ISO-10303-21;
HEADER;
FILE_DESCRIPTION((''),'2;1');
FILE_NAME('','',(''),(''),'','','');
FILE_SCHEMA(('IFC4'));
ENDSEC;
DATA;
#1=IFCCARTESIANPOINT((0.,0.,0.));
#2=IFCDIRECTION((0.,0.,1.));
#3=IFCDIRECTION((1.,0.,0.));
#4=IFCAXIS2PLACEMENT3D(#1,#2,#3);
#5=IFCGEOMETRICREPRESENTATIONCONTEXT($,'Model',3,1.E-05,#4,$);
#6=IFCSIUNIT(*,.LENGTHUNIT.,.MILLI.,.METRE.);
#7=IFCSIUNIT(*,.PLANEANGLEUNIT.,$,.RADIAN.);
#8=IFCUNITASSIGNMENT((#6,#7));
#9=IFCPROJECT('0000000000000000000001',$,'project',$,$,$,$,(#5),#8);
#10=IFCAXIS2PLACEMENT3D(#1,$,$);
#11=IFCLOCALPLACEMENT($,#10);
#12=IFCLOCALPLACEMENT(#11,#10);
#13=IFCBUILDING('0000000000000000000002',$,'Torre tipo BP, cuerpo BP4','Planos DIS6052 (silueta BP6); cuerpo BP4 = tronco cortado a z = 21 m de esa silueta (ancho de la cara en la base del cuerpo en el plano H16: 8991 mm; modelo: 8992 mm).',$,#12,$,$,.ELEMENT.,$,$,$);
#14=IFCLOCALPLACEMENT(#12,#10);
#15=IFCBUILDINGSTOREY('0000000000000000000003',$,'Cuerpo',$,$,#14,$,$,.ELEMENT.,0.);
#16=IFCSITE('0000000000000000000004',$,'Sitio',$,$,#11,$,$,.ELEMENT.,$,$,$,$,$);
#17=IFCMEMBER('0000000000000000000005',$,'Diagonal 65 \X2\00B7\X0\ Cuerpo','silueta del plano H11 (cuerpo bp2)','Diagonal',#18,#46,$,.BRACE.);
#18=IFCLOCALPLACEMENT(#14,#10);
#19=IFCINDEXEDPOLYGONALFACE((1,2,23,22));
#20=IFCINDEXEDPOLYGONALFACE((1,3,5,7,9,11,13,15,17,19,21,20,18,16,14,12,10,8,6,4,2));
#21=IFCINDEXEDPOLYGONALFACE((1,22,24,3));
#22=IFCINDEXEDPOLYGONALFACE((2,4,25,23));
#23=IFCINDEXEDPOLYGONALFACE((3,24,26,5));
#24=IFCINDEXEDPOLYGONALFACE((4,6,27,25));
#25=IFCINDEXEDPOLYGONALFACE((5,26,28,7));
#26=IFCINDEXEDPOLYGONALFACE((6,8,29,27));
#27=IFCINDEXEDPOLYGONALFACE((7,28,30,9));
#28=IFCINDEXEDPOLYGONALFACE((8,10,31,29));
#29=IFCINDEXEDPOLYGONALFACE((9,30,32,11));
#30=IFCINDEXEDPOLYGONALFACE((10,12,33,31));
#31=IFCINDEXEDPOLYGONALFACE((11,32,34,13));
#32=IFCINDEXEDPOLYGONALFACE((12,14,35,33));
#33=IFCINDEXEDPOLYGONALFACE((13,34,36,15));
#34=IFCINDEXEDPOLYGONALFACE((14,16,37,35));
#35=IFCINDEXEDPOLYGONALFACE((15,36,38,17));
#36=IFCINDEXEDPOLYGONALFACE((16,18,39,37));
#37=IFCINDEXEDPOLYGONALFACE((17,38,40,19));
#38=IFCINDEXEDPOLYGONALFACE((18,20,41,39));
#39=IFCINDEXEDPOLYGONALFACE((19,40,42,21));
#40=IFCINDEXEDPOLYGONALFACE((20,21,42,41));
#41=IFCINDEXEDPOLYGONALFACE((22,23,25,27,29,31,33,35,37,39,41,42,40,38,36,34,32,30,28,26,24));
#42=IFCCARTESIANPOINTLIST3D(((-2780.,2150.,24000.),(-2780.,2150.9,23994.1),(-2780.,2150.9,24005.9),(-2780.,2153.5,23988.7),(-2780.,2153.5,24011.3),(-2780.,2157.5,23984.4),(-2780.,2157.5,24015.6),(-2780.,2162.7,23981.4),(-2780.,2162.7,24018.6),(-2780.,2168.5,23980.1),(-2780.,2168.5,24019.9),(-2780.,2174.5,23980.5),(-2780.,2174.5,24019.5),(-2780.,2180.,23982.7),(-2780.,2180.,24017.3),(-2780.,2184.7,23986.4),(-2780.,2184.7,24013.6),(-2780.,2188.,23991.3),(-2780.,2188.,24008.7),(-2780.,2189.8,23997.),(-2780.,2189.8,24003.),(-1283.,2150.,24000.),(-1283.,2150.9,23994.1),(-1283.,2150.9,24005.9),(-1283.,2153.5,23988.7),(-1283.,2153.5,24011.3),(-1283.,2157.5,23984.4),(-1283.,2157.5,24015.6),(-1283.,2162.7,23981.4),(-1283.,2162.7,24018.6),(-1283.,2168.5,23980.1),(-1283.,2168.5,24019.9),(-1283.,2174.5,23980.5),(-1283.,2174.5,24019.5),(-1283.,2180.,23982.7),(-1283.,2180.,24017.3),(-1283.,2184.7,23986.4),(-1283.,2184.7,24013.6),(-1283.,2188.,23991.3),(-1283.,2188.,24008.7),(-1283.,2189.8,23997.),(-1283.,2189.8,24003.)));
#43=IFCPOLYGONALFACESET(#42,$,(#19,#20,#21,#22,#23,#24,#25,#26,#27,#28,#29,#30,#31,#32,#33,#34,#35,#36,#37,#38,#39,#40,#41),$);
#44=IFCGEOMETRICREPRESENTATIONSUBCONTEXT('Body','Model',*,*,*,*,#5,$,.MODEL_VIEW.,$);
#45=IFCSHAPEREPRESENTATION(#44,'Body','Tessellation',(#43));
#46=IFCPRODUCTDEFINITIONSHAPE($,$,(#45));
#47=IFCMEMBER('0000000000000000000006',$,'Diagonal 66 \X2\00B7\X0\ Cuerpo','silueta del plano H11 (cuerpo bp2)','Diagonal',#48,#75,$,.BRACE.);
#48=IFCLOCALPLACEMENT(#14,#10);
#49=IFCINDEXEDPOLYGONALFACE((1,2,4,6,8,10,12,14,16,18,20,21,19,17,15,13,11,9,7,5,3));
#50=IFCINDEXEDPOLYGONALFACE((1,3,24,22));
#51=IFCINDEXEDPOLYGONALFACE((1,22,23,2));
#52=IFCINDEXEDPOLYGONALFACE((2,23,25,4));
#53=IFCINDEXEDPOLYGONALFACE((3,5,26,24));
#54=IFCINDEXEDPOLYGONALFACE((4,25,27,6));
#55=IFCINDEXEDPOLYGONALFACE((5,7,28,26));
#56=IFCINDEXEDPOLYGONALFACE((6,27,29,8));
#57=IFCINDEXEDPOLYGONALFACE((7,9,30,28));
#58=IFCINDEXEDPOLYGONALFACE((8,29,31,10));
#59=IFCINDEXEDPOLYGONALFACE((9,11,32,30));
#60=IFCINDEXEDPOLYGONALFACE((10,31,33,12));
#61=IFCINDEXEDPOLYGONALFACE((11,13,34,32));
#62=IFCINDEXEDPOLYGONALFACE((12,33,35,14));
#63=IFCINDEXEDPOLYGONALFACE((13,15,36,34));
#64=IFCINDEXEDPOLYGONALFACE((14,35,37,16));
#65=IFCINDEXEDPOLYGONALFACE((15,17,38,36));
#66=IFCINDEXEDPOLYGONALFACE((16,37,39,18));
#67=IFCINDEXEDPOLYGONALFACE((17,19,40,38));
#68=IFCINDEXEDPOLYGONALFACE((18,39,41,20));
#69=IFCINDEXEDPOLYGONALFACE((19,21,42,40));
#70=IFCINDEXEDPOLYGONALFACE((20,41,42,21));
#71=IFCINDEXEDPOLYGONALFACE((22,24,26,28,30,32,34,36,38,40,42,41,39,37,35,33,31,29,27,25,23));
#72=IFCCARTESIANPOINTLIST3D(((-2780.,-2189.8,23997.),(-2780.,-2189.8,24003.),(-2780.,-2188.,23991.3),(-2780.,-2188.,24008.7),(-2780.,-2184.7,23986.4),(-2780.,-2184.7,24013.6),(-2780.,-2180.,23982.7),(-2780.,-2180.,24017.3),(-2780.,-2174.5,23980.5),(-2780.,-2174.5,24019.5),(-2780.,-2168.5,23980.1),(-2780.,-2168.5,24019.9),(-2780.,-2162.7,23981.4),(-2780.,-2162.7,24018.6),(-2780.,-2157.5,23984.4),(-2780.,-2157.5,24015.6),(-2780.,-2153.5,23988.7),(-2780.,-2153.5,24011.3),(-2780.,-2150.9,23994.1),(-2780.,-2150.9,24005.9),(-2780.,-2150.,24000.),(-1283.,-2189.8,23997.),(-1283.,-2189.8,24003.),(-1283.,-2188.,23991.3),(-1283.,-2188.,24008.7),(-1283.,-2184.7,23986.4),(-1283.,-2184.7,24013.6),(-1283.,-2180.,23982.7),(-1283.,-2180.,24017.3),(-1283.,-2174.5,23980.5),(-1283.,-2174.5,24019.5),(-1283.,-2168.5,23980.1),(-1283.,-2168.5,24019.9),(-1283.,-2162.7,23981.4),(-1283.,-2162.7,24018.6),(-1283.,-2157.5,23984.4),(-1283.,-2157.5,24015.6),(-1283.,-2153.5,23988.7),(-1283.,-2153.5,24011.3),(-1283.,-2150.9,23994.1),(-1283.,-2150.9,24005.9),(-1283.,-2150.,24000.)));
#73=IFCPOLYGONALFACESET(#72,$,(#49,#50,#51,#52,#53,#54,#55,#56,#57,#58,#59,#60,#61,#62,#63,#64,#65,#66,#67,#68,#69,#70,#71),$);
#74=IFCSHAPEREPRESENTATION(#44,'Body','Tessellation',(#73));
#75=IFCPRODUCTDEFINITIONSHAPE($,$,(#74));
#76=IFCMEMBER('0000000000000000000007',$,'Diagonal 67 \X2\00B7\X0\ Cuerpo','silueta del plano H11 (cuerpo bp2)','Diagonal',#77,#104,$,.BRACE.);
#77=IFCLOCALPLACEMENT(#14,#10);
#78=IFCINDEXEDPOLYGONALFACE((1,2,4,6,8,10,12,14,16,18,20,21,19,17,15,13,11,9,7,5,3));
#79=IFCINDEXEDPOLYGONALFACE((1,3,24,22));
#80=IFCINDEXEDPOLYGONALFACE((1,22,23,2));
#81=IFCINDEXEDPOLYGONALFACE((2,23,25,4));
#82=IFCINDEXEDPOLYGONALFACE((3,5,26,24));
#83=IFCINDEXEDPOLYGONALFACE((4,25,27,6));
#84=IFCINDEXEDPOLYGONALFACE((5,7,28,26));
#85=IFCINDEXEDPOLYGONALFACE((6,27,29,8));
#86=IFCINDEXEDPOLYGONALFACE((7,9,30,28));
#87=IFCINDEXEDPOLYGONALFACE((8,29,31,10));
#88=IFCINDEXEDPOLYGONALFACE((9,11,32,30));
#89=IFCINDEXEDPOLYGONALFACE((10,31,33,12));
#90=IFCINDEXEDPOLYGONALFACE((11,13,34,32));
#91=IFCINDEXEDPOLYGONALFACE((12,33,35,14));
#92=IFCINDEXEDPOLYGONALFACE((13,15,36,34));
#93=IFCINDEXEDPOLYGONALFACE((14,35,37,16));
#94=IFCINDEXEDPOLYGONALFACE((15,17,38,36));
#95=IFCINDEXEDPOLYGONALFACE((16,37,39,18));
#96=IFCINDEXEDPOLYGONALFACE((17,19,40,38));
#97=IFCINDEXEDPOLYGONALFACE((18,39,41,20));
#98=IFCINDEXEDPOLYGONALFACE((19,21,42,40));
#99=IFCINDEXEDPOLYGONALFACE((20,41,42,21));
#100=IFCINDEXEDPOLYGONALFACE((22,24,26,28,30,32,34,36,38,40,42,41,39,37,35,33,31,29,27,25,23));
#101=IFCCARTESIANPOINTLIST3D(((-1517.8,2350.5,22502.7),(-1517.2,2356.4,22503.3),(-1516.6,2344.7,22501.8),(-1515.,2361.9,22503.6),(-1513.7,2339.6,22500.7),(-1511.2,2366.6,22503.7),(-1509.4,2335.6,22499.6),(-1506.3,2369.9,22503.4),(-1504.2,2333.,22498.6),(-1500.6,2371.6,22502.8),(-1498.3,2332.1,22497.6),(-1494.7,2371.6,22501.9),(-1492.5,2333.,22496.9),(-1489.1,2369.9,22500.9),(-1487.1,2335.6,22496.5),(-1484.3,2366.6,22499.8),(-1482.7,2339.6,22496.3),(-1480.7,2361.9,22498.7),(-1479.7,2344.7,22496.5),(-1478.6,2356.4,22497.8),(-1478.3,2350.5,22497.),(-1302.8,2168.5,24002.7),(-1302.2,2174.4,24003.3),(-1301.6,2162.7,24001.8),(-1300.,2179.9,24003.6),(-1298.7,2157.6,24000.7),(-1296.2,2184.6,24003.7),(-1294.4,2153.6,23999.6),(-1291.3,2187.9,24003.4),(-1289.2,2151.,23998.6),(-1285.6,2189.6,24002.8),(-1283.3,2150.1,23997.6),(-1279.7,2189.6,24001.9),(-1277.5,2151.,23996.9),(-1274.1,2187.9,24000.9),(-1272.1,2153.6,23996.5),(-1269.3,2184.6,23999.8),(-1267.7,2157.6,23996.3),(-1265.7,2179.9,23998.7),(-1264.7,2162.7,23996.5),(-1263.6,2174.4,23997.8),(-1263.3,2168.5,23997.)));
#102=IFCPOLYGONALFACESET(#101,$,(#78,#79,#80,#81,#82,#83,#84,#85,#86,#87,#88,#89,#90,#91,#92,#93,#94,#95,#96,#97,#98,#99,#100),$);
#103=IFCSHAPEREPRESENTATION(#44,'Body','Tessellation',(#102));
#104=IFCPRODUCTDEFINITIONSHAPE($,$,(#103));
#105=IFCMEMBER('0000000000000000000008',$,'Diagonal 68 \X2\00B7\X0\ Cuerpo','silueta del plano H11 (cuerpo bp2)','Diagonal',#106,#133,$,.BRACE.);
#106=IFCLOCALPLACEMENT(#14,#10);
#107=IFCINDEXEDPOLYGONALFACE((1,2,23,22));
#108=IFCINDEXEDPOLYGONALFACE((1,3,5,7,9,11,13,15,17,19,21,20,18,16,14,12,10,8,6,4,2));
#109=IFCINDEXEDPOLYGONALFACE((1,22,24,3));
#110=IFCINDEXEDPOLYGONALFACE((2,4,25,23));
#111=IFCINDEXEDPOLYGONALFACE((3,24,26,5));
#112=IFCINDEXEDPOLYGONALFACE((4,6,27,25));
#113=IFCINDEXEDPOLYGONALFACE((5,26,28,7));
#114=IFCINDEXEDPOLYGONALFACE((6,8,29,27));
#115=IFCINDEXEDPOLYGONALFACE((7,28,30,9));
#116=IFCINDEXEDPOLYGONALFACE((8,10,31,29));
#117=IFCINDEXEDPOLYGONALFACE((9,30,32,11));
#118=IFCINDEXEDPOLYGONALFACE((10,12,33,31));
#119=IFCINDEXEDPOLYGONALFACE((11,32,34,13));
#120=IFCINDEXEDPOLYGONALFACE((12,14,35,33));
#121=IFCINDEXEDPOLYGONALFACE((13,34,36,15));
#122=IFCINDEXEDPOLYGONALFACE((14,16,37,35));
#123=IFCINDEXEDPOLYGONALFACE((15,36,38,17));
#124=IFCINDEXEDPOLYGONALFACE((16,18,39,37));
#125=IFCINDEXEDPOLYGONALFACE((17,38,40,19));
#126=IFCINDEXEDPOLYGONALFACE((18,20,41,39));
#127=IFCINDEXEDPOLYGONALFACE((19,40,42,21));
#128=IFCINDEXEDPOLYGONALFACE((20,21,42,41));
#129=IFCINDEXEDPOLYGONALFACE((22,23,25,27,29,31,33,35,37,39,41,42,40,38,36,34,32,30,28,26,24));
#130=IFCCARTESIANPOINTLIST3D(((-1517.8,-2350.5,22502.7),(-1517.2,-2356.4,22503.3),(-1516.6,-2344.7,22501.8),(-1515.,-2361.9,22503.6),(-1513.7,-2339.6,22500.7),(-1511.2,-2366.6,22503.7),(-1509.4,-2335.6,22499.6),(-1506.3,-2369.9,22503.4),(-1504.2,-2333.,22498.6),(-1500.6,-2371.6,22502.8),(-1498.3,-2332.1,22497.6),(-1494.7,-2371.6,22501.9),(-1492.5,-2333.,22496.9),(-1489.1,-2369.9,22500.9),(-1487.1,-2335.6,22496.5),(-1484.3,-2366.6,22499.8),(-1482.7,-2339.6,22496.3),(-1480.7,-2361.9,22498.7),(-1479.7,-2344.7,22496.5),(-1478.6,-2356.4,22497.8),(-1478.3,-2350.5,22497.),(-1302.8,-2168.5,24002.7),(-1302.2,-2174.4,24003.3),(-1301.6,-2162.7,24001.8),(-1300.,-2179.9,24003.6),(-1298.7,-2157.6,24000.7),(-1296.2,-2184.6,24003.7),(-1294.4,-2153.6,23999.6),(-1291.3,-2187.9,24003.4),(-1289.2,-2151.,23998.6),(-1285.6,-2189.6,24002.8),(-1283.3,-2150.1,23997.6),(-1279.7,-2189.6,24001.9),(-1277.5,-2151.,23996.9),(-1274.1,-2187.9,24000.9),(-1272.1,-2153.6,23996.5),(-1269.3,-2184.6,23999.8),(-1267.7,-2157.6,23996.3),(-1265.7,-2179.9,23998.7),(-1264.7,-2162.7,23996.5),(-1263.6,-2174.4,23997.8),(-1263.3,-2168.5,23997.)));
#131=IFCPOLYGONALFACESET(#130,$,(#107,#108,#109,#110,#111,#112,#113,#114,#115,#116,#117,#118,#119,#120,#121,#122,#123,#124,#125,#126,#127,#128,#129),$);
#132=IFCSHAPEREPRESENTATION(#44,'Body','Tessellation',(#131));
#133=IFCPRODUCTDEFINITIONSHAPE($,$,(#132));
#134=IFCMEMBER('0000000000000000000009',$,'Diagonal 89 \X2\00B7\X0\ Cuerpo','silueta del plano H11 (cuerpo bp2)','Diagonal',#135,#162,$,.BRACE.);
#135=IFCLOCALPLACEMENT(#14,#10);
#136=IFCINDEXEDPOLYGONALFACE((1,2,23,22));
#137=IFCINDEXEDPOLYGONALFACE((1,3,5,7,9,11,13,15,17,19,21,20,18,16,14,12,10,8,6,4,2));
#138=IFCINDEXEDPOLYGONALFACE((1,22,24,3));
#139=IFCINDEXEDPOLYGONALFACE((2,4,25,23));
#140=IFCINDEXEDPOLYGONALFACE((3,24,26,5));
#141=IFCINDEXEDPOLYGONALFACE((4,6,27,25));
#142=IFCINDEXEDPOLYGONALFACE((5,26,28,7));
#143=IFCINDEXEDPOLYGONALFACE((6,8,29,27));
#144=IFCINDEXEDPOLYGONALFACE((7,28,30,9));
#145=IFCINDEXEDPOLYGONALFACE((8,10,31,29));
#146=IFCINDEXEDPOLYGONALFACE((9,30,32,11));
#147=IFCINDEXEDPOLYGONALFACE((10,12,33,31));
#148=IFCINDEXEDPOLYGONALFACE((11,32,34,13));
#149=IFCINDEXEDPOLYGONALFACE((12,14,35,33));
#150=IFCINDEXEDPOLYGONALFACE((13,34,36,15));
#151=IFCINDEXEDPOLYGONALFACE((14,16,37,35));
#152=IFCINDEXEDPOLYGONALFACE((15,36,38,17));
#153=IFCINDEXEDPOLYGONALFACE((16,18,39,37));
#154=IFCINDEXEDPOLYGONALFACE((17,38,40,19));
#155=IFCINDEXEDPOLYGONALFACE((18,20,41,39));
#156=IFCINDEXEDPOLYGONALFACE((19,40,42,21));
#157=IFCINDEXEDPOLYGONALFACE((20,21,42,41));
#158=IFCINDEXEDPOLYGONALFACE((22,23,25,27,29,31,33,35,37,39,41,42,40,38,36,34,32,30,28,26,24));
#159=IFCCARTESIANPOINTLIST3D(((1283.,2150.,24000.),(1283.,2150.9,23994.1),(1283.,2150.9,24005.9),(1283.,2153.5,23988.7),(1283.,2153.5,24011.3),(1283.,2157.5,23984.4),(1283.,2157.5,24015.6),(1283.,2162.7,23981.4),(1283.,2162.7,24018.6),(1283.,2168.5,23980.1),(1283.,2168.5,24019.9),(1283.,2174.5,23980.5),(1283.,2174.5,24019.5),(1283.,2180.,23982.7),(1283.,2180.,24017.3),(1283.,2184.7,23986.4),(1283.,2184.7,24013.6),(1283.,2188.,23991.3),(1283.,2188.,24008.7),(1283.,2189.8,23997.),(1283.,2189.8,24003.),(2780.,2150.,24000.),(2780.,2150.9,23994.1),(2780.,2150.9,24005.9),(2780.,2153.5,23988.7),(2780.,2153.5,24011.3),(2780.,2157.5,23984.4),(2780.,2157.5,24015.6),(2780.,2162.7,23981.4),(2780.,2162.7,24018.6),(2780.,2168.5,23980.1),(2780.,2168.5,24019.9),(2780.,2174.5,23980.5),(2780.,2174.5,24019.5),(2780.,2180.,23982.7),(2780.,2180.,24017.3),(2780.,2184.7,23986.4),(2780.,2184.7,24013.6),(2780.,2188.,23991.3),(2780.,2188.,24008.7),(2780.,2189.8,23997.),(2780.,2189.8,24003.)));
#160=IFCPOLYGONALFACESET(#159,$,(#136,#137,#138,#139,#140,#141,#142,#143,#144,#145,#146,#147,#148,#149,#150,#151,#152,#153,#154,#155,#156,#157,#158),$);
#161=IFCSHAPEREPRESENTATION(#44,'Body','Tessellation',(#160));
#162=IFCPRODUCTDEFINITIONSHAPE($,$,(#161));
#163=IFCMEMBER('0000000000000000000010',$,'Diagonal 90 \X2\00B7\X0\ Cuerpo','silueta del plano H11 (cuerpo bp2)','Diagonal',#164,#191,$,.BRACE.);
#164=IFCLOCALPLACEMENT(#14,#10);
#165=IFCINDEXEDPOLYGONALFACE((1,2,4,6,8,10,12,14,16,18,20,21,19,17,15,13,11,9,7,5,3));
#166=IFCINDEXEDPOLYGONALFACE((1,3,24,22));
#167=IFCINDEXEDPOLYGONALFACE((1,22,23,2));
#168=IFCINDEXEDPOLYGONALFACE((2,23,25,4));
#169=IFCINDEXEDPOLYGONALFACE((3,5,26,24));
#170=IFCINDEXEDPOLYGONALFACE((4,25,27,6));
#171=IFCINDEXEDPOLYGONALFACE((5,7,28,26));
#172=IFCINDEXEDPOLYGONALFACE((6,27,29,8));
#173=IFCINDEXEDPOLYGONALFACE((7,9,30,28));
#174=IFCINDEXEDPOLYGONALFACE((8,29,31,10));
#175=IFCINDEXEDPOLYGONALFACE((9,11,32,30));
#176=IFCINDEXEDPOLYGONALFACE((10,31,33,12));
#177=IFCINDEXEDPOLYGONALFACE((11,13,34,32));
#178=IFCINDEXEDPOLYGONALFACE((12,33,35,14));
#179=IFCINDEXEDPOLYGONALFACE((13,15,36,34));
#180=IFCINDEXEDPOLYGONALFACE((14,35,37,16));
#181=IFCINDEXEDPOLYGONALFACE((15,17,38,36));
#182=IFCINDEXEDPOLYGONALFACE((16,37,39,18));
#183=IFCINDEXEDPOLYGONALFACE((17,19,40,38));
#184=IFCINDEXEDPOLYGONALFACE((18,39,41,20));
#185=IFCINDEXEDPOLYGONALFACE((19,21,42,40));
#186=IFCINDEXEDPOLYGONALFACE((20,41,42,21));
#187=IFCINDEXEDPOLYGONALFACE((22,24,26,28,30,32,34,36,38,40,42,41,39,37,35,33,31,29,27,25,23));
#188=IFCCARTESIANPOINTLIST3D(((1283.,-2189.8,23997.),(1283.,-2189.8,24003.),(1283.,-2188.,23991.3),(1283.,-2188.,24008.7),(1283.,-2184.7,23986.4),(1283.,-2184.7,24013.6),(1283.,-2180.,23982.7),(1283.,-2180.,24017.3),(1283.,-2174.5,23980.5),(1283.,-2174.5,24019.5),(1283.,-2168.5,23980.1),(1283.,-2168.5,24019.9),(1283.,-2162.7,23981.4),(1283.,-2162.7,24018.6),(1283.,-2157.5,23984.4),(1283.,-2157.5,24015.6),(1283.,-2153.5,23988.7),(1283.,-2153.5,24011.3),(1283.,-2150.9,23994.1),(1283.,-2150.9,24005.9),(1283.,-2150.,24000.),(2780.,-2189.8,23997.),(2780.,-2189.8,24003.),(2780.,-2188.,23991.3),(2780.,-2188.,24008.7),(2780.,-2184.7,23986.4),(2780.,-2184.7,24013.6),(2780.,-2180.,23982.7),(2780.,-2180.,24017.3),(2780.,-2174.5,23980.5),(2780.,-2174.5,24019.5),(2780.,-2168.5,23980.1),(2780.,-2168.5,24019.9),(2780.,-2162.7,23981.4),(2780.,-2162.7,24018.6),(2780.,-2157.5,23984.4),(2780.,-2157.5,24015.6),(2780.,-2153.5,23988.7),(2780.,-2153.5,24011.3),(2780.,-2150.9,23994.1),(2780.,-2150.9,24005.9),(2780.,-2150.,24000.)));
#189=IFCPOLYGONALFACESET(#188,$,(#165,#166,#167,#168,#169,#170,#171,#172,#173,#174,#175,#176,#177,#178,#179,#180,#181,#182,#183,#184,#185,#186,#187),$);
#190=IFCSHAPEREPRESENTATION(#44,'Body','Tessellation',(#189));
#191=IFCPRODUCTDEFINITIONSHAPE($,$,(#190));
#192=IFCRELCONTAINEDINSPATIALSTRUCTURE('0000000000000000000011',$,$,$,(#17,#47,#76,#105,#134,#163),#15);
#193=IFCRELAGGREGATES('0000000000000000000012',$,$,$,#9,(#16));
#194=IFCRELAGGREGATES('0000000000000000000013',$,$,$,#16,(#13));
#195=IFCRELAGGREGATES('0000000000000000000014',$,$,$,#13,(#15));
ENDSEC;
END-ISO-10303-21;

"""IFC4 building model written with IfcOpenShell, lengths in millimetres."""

from ifc_helpers import new_model, si_unit, frame, origin, origin_with_axes, place, context, subcontext, project, spatial, circle, extrude, element, save


model = new_model("IFC4")

# Units and contexts
model_context = context("Model", 3, precision=1e-05, world=origin_with_axes())
body_context = subcontext(model_context, "Body", "Model", "MODEL_VIEW")
ifc_project = project(units=[si_unit("LENGTHUNIT", "METRE", prefix="MILLI"), si_unit("PLANEANGLEUNIT", "RADIAN")], contexts=[model_context])

# Site, building, storey
site_placement = place(None, origin())
site = spatial("IfcSite", under=ifc_project, at=site_placement, Name="Sitio", CompositionType="ELEMENT")
building_placement = place(site_placement, origin())
building = spatial("IfcBuilding", under=site, at=building_placement, Name="Torre tipo BP, cuerpo BP4", Description="Planos DIS6052 (silueta BP6); cuerpo BP4 = tronco cortado a z = 21 m de esa silueta (ancho de la cara en la base del cuerpo en el plano H16: 8991 mm; modelo: 8992 mm).", CompositionType="ELEMENT")
storey_placement = place(building_placement, origin())
storey = spatial("IfcBuildingStorey", under=building, at=storey_placement, Name="Cuerpo", CompositionType="ELEMENT", Elevation=0.0)

# Members
for number, where, z_axis, x_axis, name in (
    (1, (-2780.0, 2170.0, 24000.0), (1.0, 0.0, 0.0), (0.0, -1.0, 0.0), "Diagonal 65 · Cuerpo"),
    (2, (-2780.0, -2170.0, 24000.0), (1.0, 0.0, 0.0), (0.0, 1.0, 0.0), "Diagonal 66 · Cuerpo"),
):
    element("IfcMember", number, at=place(storey_placement, frame(where, z_axis=z_axis, x_axis=x_axis)), inside=storey, Name=name, Description="silueta del plano H11 (cuerpo bp2)", ObjectType="Diagonal", PredefinedType="BRACE", context=body_context, shape_type="SweptSolid", body=[
        extrude(circle(Radius=20.0), None, (0.0, 0.0, 1.0), 1497.0),
    ])
for number, where, z_axis, x_axis, name in (
    (3, (-1283.0, 2170.0, 24000.0), (-0.140871, 0.119249, -0.98282), (-0.016919, -0.992864, -0.118042), "Diagonal 67 · Cuerpo"),
    (4, (-1283.0, -2170.0, 24000.0), (-0.140871, -0.119249, -0.98282), (-0.016919, 0.992864, -0.118042), "Diagonal 68 · Cuerpo"),
):
    element("IfcMember", number, at=place(storey_placement, frame(where, z_axis=z_axis, x_axis=x_axis)), inside=storey, Name=name, Description="silueta del plano H11 (cuerpo bp2)", ObjectType="Diagonal", PredefinedType="BRACE", context=body_context, shape_type="SweptSolid", body=[
        extrude(circle(Radius=20.0), None, (0.0, 0.0, 1.0), 1526.2),
    ])
for number, where, z_axis, x_axis, name in (
    (5, (2780.0, 2170.0, 24000.0), (-1.0, 0.0, 0.0), (0.0, -1.0, 0.0), "Diagonal 89 · Cuerpo"),
    (6, (2780.0, -2170.0, 24000.0), (-1.0, 0.0, 0.0), (0.0, 1.0, 0.0), "Diagonal 90 · Cuerpo"),
):
    element("IfcMember", number, at=place(storey_placement, frame(where, z_axis=z_axis, x_axis=x_axis)), inside=storey, Name=name, Description="silueta del plano H11 (cuerpo bp2)", ObjectType="Diagonal", PredefinedType="BRACE", context=body_context, shape_type="SweptSolid", body=[
        extrude(circle(Radius=20.0), None, (0.0, 0.0, 1.0), 1497.0),
    ])

save(model, "model.ifc")
